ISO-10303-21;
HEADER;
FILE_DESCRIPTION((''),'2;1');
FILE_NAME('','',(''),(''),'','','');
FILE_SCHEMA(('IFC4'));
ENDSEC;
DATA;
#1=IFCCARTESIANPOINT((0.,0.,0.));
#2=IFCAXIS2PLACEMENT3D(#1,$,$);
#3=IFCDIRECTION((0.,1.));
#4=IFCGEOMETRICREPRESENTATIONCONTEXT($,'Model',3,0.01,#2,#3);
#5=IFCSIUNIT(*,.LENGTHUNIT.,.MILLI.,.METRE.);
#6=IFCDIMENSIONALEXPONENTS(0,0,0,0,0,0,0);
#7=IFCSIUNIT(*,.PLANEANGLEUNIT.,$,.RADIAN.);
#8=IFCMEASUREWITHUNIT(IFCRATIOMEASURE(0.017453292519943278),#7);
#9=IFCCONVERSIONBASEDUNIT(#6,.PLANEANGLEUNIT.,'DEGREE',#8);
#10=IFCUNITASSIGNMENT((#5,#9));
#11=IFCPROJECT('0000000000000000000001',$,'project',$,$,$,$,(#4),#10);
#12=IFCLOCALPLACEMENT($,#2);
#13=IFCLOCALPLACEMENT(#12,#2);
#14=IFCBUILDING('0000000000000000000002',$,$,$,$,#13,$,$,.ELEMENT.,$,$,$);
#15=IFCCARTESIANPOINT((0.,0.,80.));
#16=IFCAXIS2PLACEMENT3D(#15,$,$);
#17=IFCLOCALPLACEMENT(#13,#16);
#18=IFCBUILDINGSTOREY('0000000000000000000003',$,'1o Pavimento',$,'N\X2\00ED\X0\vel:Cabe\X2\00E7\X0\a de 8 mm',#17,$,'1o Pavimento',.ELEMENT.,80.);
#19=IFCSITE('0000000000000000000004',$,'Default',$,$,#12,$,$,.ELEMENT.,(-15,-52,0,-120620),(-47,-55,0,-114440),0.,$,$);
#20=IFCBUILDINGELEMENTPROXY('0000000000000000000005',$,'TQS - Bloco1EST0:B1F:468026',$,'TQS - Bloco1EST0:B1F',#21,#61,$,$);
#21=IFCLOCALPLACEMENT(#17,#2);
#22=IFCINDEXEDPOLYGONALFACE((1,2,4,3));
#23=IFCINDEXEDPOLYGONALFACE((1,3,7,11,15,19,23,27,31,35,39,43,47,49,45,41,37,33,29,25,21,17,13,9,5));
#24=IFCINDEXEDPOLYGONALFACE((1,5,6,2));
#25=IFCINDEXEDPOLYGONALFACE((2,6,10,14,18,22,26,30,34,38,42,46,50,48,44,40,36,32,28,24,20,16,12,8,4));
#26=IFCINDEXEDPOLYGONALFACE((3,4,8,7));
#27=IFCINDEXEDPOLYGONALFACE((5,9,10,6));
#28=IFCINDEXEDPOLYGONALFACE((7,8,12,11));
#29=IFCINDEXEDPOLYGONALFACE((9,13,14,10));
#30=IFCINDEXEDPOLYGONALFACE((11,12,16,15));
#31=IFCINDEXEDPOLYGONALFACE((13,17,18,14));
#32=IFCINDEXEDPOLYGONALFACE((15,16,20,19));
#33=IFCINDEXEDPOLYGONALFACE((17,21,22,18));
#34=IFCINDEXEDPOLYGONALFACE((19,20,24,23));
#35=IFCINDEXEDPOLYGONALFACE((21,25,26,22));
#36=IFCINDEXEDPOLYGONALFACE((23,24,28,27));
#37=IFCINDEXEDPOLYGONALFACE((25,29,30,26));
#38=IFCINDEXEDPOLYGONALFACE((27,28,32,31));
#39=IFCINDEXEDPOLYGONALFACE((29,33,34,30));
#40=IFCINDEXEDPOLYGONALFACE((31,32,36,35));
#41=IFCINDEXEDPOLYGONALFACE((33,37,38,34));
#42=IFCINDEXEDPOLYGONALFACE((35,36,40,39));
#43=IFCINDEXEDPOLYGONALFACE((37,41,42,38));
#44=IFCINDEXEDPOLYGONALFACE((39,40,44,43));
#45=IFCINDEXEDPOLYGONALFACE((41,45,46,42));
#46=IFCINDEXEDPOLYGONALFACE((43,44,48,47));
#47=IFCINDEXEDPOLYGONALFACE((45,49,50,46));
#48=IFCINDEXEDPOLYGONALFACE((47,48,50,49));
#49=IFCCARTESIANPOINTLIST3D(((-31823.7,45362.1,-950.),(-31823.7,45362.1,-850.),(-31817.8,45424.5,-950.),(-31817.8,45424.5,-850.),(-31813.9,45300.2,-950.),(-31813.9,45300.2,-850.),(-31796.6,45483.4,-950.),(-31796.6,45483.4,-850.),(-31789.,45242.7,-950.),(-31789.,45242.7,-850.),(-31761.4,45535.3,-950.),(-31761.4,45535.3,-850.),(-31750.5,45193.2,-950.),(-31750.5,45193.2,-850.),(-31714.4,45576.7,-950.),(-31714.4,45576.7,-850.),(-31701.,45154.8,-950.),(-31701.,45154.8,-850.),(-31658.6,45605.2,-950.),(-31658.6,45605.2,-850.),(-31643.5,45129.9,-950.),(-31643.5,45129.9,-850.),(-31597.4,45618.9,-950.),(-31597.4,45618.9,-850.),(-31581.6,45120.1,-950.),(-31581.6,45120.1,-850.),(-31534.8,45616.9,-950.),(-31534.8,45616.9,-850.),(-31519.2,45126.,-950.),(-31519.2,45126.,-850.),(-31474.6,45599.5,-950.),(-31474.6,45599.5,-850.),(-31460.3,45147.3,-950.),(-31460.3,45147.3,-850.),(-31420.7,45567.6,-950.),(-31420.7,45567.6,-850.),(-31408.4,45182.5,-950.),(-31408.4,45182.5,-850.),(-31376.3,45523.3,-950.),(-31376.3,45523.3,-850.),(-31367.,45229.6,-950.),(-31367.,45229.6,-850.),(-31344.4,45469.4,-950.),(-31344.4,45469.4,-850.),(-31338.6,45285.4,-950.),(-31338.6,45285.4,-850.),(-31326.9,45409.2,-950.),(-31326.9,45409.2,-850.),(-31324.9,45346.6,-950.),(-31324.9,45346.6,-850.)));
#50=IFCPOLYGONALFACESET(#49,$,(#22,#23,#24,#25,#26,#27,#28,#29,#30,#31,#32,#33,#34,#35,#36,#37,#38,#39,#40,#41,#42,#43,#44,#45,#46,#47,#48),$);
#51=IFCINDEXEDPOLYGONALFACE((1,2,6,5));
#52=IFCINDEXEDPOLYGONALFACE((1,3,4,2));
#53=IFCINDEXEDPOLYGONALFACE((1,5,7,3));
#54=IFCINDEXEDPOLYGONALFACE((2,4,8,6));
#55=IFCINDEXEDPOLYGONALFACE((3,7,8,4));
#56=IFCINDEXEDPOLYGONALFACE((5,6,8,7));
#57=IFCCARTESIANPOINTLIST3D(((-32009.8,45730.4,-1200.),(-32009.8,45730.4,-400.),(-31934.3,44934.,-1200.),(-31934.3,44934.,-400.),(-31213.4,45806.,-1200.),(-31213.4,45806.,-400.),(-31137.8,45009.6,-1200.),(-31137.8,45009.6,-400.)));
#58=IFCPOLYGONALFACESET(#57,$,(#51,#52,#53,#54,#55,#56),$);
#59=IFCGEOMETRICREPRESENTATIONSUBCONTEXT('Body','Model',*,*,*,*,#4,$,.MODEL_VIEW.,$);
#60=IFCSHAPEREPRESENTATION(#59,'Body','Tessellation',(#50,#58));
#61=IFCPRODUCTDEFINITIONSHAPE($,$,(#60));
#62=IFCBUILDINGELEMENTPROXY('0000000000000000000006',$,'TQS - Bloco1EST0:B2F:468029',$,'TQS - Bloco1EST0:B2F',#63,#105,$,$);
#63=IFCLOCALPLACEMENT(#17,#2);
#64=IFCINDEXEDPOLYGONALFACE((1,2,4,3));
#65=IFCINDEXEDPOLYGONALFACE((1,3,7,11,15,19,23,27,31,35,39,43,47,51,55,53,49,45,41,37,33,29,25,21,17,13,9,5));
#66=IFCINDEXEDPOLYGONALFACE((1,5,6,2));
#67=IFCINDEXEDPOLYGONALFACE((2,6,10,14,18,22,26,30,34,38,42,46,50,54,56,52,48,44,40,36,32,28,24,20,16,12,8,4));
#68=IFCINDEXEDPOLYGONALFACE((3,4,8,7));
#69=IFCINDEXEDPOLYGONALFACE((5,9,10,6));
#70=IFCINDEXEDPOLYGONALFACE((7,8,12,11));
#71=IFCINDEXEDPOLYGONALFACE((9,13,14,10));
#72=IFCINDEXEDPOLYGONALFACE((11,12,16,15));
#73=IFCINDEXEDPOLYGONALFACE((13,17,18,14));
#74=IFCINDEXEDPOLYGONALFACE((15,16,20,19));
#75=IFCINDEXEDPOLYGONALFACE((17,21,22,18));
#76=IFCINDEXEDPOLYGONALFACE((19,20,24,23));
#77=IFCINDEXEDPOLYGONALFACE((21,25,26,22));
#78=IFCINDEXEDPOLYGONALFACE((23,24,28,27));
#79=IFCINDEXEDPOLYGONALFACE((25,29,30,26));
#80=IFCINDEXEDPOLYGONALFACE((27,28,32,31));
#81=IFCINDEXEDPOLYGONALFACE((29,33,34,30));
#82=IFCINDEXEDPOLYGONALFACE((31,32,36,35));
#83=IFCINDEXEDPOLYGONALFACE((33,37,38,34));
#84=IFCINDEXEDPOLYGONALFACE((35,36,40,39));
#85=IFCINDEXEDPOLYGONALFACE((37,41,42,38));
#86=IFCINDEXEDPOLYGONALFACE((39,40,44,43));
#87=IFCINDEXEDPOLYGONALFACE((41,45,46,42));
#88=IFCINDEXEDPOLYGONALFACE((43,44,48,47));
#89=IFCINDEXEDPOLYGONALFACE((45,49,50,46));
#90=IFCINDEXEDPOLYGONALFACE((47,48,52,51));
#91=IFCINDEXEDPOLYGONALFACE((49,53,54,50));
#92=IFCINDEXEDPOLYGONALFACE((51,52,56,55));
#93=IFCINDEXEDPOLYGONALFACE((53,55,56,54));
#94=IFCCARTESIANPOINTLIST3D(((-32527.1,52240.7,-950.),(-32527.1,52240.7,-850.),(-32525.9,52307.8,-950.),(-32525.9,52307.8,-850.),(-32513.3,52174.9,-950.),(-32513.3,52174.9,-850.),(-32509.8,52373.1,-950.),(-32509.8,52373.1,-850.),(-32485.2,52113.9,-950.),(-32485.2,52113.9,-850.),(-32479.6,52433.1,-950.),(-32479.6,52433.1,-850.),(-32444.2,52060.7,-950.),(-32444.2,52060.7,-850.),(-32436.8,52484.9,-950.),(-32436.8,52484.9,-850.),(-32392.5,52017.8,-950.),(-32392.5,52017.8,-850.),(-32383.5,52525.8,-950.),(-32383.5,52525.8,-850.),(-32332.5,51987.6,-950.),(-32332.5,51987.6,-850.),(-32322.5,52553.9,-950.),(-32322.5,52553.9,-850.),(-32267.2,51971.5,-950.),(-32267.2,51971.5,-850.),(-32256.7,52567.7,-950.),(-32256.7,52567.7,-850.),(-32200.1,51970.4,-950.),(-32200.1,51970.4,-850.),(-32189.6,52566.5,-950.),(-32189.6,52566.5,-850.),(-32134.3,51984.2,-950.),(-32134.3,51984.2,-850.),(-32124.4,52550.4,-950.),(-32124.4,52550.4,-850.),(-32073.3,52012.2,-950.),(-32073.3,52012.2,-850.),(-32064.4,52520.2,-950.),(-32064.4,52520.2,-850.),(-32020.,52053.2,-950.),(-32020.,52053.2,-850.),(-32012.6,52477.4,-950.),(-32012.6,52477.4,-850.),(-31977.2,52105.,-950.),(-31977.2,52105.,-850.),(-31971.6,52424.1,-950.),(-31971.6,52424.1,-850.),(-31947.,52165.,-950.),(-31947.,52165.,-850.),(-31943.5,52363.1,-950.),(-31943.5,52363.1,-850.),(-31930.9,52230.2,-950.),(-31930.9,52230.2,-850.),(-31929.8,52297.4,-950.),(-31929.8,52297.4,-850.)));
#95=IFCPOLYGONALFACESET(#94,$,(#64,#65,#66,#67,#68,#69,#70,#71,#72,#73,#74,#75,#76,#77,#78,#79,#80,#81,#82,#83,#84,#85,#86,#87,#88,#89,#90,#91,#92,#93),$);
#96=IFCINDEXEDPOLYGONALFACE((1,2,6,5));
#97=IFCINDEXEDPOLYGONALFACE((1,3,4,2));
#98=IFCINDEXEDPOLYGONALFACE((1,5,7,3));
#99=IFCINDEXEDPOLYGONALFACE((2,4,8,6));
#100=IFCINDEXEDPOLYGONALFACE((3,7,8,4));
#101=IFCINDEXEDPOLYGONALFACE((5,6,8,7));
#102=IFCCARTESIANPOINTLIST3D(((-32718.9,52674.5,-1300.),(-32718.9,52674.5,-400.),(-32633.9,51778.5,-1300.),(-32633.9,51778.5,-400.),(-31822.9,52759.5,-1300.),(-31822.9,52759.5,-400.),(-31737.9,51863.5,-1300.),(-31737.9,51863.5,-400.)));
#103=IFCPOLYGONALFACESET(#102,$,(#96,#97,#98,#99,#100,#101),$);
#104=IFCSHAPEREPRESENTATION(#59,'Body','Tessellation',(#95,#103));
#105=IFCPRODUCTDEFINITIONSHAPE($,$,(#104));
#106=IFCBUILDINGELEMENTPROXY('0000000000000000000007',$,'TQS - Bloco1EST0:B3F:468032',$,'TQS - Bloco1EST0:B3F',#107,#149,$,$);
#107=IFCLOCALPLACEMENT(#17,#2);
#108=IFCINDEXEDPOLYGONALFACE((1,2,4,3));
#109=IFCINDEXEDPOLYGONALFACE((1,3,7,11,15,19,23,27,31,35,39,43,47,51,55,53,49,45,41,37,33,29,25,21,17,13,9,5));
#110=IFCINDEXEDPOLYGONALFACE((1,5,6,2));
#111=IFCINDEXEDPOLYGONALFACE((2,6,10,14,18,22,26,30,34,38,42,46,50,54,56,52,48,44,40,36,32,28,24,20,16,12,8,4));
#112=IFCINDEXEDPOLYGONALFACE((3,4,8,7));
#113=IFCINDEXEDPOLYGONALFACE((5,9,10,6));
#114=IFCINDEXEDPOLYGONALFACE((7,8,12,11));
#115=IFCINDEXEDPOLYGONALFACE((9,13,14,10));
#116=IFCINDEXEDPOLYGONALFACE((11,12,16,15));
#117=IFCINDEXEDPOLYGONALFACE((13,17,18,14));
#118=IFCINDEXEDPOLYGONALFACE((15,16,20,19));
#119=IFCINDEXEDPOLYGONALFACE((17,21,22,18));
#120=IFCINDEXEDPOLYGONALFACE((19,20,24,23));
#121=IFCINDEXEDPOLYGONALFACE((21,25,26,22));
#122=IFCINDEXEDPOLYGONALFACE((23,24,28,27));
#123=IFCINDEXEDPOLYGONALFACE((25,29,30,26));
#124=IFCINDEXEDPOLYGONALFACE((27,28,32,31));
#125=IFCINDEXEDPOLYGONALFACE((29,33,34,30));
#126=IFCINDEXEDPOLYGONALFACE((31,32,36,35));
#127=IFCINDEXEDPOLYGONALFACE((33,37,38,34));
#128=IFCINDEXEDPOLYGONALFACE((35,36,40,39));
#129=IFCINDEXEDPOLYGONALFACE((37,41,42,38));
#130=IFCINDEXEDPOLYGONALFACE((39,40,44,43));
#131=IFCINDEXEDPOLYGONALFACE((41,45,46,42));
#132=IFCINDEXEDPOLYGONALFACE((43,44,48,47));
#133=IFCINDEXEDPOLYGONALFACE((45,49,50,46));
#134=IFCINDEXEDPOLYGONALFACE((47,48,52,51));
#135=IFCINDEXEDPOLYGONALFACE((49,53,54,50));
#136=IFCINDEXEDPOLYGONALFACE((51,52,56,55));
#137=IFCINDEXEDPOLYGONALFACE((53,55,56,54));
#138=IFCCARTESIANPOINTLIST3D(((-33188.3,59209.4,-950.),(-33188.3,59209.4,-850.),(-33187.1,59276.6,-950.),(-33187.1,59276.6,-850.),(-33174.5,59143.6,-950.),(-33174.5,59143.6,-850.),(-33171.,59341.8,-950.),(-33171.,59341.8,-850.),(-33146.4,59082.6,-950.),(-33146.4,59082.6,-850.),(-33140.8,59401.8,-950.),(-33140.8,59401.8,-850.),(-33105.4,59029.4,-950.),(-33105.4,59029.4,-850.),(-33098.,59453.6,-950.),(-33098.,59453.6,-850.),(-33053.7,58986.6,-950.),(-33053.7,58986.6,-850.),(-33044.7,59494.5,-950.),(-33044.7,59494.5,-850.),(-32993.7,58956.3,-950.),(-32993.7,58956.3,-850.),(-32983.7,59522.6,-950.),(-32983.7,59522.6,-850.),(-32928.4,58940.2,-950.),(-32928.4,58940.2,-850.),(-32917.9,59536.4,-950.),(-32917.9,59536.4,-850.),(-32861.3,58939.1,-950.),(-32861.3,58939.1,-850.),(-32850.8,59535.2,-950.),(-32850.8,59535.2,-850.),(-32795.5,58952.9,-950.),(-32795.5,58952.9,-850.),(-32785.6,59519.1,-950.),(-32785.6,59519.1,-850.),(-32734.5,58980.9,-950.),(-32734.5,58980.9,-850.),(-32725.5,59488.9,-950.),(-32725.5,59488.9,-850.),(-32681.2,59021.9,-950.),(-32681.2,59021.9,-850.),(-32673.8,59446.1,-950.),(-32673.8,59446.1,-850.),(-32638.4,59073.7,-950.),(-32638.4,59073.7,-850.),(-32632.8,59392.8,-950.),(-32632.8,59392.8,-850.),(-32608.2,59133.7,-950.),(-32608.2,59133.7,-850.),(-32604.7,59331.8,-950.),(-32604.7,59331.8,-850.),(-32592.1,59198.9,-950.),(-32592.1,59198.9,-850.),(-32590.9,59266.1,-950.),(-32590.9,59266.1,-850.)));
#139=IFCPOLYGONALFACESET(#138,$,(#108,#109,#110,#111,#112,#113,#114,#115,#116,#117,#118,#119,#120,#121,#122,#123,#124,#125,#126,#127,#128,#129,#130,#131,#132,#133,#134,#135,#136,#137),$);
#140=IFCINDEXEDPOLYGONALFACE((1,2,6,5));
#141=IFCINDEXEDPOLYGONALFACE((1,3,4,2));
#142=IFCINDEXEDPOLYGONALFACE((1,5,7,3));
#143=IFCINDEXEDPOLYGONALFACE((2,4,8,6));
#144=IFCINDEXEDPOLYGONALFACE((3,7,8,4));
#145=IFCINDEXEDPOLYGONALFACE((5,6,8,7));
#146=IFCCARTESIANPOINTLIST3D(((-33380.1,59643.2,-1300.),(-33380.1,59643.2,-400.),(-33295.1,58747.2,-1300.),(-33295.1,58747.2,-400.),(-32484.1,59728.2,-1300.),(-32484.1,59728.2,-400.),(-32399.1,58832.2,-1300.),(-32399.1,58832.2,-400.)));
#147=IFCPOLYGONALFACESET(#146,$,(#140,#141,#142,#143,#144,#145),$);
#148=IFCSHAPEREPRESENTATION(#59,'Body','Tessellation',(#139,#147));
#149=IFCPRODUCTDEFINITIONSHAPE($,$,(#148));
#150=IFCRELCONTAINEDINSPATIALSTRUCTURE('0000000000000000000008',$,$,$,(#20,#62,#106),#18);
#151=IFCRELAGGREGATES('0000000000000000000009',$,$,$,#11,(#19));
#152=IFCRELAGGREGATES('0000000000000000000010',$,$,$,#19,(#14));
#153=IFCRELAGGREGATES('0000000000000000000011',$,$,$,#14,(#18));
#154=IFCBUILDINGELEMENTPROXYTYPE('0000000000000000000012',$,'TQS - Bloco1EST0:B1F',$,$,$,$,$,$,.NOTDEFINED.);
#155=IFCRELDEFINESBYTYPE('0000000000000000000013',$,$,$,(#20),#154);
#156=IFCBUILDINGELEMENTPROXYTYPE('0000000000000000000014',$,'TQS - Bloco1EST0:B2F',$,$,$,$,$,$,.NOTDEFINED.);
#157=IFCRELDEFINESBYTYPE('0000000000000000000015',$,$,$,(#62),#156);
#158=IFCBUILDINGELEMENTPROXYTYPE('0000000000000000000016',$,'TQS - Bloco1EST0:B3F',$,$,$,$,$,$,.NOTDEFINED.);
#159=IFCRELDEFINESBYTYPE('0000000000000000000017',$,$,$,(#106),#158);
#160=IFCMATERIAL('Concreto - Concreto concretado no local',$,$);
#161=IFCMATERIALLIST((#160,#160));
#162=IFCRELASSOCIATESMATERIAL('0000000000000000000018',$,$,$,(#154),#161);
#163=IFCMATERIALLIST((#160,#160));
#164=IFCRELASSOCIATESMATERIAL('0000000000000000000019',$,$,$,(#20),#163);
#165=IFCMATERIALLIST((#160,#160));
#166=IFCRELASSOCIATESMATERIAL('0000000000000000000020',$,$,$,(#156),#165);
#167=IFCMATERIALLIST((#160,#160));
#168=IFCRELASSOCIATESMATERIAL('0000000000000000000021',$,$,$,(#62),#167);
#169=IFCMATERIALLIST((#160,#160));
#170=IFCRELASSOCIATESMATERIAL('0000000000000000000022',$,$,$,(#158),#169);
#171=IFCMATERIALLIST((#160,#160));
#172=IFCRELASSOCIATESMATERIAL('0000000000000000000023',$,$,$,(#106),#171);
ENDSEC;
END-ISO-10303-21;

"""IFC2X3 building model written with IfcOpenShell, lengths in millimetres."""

from ifc_helpers import new_model, entity, si_unit, converted_unit, direction, frame, frame_2d, origin, origin_2d_with_axis, place, context, subcontext, project, spatial, rectangle, circle, extrude, source, transform, mapped, material, material_list, type_object, type_shapes, element, save


model = new_model("IFC2X3")

# Units and contexts
model_context = context("Model", 3, precision=0.01, world=origin(), true_north=direction((0.0, 1.0)))
body_context = subcontext(model_context, "Body", "Model", "MODEL_VIEW")
ifc_project = project(units=[si_unit("LENGTHUNIT", "METRE", prefix="MILLI"), converted_unit("PLANEANGLEUNIT", "DEGREE", entity("IfcRatioMeasure", 0.017453292519943278), si_unit("PLANEANGLEUNIT", "RADIAN"), dimensions=[0, 0, 0, 0, 0, 0, 0])], contexts=[model_context])

# Site, building, storey
site_placement = place(None, origin())
site = spatial("IfcSite", under=ifc_project, at=site_placement, Name="Default", CompositionType="ELEMENT", RefLatitude=(-15, -52, 0, -120620), RefLongitude=(-47, -55, 0, -114440), RefElevation=0.0)
building_placement = place(site_placement, origin())
building = spatial("IfcBuilding", under=site, at=building_placement, CompositionType="ELEMENT")
storey_placement = place(building_placement, frame((0.0, 0.0, 80.0)))
storey = spatial("IfcBuildingStorey", under=building, at=storey_placement, Name="1o Pavimento", ObjectType="Nível:Cabeça de 8 mm", LongName="1o Pavimento", CompositionType="ELEMENT", Elevation=80.0)

# Building element proxies
ifc_material_1 = material(Name="Concreto - Concreto concretado no local")
ifc_material_list_1 = material_list([ifc_material_1, ifc_material_1])
ifc_material_list_2 = material_list([ifc_material_1, ifc_material_1])
building_element_proxy_type_1 = type_object("IfcBuildingElementProxyType", Name="TQS - Bloco1EST0:B1F", PredefinedType="NOTDEFINED", material=ifc_material_list_2)
shared_shape_1 = source(origin(), body_context, "Body", "SweptSolid", [
    extrude(circle(Radius=250.0, at=frame_2d((0.0, 0.0), x_axis=(1.0, 0.0))), frame((0.0, 0.0, -550.0)), (0.0, 0.0, 1.0), 100.0),
    extrude(rectangle(XDim=800.0, YDim=800.0, at=origin_2d_with_axis()), frame((0.0, 0.0, -800.0), z_axis=(0.0, 0.0, 1.0), x_axis=(-1.0, 0.0, 0.0)), (0.0, 0.0, 1.0), 800.0),
])
type_shapes(building_element_proxy_type_1, [shared_shape_1])
proxy_1_placement = place(storey_placement, frame((-31573.8, 45370.0, -400.0), z_axis=(0.0, 0.0, 1.0), x_axis=(-0.094456, 0.995529, 0.0)))
element("IfcBuildingElementProxy", 1, at=proxy_1_placement, inside=storey, type_object=building_element_proxy_type_1, material=ifc_material_list_1, Name="TQS - Bloco1EST0:B1F:468026", ObjectType="TQS - Bloco1EST0:B1F", context=body_context, shape_type="MappedRepresentation", body=[
    mapped(shared_shape_1, transform((0.0, 0.0, 0.0), scale=1.0)),
])
ifc_material_list_3 = material_list([ifc_material_1, ifc_material_1])
ifc_material_list_4 = material_list([ifc_material_1, ifc_material_1])
building_element_proxy_type_2 = type_object("IfcBuildingElementProxyType", Name="TQS - Bloco1EST0:B2F", PredefinedType="NOTDEFINED", material=ifc_material_list_4)
shared_shape_2 = source(origin(), body_context, "Body", "SweptSolid", [
    extrude(circle(Radius=300.0, at=frame_2d((0.0, 0.0), x_axis=(1.0, 0.0))), frame((0.0, 0.0, -550.0)), (0.0, 0.0, 1.0), 100.0),
    extrude(rectangle(XDim=900.0, YDim=900.0, at=origin_2d_with_axis()), frame((0.0, 0.0, -900.0), z_axis=(0.0, 0.0, 1.0), x_axis=(-1.0, 0.0, 0.0)), (0.0, 0.0, 1.0), 900.0),
])
type_shapes(building_element_proxy_type_2, [shared_shape_2])
proxy_2_placement = place(storey_placement, frame((-32228.4, 52269.0, -400.0), z_axis=(0.0, 0.0, 1.0), x_axis=(-0.094456, 0.995529, 0.0)))
element("IfcBuildingElementProxy", 2, at=proxy_2_placement, inside=storey, type_object=building_element_proxy_type_2, material=ifc_material_list_3, Name="TQS - Bloco1EST0:B2F:468029", ObjectType="TQS - Bloco1EST0:B2F", context=body_context, shape_type="MappedRepresentation", body=[
    mapped(shared_shape_2, transform((0.0, 0.0, 0.0), scale=1.0)),
])
ifc_material_list_5 = material_list([ifc_material_1, ifc_material_1])
ifc_material_list_6 = material_list([ifc_material_1, ifc_material_1])
building_element_proxy_type_3 = type_object("IfcBuildingElementProxyType", Name="TQS - Bloco1EST0:B3F", PredefinedType="NOTDEFINED", material=ifc_material_list_6)
shared_shape_3 = source(origin(), body_context, "Body", "SweptSolid", [
    extrude(circle(Radius=300.0, at=frame_2d((0.0, 0.0), x_axis=(1.0, 0.0))), frame((0.0, 0.0, -550.0)), (0.0, 0.0, 1.0), 100.0),
    extrude(rectangle(XDim=900.0, YDim=900.0, at=origin_2d_with_axis()), frame((0.0, 0.0, -900.0), z_axis=(0.0, 0.0, 1.0), x_axis=(-1.0, 0.0, 0.0)), (0.0, 0.0, 1.0), 900.0),
])
type_shapes(building_element_proxy_type_3, [shared_shape_3])
proxy_3_placement = place(storey_placement, frame((-32889.6, 59237.7, -400.0), z_axis=(0.0, 0.0, 1.0), x_axis=(-0.094456, 0.995529, 0.0)))
element("IfcBuildingElementProxy", 3, at=proxy_3_placement, inside=storey, type_object=building_element_proxy_type_3, material=ifc_material_list_5, Name="TQS - Bloco1EST0:B3F:468032", ObjectType="TQS - Bloco1EST0:B3F", context=body_context, shape_type="MappedRepresentation", body=[
    mapped(shared_shape_3, transform((0.0, 0.0, 0.0), scale=1.0)),
])

save(model, "model.ifc")
